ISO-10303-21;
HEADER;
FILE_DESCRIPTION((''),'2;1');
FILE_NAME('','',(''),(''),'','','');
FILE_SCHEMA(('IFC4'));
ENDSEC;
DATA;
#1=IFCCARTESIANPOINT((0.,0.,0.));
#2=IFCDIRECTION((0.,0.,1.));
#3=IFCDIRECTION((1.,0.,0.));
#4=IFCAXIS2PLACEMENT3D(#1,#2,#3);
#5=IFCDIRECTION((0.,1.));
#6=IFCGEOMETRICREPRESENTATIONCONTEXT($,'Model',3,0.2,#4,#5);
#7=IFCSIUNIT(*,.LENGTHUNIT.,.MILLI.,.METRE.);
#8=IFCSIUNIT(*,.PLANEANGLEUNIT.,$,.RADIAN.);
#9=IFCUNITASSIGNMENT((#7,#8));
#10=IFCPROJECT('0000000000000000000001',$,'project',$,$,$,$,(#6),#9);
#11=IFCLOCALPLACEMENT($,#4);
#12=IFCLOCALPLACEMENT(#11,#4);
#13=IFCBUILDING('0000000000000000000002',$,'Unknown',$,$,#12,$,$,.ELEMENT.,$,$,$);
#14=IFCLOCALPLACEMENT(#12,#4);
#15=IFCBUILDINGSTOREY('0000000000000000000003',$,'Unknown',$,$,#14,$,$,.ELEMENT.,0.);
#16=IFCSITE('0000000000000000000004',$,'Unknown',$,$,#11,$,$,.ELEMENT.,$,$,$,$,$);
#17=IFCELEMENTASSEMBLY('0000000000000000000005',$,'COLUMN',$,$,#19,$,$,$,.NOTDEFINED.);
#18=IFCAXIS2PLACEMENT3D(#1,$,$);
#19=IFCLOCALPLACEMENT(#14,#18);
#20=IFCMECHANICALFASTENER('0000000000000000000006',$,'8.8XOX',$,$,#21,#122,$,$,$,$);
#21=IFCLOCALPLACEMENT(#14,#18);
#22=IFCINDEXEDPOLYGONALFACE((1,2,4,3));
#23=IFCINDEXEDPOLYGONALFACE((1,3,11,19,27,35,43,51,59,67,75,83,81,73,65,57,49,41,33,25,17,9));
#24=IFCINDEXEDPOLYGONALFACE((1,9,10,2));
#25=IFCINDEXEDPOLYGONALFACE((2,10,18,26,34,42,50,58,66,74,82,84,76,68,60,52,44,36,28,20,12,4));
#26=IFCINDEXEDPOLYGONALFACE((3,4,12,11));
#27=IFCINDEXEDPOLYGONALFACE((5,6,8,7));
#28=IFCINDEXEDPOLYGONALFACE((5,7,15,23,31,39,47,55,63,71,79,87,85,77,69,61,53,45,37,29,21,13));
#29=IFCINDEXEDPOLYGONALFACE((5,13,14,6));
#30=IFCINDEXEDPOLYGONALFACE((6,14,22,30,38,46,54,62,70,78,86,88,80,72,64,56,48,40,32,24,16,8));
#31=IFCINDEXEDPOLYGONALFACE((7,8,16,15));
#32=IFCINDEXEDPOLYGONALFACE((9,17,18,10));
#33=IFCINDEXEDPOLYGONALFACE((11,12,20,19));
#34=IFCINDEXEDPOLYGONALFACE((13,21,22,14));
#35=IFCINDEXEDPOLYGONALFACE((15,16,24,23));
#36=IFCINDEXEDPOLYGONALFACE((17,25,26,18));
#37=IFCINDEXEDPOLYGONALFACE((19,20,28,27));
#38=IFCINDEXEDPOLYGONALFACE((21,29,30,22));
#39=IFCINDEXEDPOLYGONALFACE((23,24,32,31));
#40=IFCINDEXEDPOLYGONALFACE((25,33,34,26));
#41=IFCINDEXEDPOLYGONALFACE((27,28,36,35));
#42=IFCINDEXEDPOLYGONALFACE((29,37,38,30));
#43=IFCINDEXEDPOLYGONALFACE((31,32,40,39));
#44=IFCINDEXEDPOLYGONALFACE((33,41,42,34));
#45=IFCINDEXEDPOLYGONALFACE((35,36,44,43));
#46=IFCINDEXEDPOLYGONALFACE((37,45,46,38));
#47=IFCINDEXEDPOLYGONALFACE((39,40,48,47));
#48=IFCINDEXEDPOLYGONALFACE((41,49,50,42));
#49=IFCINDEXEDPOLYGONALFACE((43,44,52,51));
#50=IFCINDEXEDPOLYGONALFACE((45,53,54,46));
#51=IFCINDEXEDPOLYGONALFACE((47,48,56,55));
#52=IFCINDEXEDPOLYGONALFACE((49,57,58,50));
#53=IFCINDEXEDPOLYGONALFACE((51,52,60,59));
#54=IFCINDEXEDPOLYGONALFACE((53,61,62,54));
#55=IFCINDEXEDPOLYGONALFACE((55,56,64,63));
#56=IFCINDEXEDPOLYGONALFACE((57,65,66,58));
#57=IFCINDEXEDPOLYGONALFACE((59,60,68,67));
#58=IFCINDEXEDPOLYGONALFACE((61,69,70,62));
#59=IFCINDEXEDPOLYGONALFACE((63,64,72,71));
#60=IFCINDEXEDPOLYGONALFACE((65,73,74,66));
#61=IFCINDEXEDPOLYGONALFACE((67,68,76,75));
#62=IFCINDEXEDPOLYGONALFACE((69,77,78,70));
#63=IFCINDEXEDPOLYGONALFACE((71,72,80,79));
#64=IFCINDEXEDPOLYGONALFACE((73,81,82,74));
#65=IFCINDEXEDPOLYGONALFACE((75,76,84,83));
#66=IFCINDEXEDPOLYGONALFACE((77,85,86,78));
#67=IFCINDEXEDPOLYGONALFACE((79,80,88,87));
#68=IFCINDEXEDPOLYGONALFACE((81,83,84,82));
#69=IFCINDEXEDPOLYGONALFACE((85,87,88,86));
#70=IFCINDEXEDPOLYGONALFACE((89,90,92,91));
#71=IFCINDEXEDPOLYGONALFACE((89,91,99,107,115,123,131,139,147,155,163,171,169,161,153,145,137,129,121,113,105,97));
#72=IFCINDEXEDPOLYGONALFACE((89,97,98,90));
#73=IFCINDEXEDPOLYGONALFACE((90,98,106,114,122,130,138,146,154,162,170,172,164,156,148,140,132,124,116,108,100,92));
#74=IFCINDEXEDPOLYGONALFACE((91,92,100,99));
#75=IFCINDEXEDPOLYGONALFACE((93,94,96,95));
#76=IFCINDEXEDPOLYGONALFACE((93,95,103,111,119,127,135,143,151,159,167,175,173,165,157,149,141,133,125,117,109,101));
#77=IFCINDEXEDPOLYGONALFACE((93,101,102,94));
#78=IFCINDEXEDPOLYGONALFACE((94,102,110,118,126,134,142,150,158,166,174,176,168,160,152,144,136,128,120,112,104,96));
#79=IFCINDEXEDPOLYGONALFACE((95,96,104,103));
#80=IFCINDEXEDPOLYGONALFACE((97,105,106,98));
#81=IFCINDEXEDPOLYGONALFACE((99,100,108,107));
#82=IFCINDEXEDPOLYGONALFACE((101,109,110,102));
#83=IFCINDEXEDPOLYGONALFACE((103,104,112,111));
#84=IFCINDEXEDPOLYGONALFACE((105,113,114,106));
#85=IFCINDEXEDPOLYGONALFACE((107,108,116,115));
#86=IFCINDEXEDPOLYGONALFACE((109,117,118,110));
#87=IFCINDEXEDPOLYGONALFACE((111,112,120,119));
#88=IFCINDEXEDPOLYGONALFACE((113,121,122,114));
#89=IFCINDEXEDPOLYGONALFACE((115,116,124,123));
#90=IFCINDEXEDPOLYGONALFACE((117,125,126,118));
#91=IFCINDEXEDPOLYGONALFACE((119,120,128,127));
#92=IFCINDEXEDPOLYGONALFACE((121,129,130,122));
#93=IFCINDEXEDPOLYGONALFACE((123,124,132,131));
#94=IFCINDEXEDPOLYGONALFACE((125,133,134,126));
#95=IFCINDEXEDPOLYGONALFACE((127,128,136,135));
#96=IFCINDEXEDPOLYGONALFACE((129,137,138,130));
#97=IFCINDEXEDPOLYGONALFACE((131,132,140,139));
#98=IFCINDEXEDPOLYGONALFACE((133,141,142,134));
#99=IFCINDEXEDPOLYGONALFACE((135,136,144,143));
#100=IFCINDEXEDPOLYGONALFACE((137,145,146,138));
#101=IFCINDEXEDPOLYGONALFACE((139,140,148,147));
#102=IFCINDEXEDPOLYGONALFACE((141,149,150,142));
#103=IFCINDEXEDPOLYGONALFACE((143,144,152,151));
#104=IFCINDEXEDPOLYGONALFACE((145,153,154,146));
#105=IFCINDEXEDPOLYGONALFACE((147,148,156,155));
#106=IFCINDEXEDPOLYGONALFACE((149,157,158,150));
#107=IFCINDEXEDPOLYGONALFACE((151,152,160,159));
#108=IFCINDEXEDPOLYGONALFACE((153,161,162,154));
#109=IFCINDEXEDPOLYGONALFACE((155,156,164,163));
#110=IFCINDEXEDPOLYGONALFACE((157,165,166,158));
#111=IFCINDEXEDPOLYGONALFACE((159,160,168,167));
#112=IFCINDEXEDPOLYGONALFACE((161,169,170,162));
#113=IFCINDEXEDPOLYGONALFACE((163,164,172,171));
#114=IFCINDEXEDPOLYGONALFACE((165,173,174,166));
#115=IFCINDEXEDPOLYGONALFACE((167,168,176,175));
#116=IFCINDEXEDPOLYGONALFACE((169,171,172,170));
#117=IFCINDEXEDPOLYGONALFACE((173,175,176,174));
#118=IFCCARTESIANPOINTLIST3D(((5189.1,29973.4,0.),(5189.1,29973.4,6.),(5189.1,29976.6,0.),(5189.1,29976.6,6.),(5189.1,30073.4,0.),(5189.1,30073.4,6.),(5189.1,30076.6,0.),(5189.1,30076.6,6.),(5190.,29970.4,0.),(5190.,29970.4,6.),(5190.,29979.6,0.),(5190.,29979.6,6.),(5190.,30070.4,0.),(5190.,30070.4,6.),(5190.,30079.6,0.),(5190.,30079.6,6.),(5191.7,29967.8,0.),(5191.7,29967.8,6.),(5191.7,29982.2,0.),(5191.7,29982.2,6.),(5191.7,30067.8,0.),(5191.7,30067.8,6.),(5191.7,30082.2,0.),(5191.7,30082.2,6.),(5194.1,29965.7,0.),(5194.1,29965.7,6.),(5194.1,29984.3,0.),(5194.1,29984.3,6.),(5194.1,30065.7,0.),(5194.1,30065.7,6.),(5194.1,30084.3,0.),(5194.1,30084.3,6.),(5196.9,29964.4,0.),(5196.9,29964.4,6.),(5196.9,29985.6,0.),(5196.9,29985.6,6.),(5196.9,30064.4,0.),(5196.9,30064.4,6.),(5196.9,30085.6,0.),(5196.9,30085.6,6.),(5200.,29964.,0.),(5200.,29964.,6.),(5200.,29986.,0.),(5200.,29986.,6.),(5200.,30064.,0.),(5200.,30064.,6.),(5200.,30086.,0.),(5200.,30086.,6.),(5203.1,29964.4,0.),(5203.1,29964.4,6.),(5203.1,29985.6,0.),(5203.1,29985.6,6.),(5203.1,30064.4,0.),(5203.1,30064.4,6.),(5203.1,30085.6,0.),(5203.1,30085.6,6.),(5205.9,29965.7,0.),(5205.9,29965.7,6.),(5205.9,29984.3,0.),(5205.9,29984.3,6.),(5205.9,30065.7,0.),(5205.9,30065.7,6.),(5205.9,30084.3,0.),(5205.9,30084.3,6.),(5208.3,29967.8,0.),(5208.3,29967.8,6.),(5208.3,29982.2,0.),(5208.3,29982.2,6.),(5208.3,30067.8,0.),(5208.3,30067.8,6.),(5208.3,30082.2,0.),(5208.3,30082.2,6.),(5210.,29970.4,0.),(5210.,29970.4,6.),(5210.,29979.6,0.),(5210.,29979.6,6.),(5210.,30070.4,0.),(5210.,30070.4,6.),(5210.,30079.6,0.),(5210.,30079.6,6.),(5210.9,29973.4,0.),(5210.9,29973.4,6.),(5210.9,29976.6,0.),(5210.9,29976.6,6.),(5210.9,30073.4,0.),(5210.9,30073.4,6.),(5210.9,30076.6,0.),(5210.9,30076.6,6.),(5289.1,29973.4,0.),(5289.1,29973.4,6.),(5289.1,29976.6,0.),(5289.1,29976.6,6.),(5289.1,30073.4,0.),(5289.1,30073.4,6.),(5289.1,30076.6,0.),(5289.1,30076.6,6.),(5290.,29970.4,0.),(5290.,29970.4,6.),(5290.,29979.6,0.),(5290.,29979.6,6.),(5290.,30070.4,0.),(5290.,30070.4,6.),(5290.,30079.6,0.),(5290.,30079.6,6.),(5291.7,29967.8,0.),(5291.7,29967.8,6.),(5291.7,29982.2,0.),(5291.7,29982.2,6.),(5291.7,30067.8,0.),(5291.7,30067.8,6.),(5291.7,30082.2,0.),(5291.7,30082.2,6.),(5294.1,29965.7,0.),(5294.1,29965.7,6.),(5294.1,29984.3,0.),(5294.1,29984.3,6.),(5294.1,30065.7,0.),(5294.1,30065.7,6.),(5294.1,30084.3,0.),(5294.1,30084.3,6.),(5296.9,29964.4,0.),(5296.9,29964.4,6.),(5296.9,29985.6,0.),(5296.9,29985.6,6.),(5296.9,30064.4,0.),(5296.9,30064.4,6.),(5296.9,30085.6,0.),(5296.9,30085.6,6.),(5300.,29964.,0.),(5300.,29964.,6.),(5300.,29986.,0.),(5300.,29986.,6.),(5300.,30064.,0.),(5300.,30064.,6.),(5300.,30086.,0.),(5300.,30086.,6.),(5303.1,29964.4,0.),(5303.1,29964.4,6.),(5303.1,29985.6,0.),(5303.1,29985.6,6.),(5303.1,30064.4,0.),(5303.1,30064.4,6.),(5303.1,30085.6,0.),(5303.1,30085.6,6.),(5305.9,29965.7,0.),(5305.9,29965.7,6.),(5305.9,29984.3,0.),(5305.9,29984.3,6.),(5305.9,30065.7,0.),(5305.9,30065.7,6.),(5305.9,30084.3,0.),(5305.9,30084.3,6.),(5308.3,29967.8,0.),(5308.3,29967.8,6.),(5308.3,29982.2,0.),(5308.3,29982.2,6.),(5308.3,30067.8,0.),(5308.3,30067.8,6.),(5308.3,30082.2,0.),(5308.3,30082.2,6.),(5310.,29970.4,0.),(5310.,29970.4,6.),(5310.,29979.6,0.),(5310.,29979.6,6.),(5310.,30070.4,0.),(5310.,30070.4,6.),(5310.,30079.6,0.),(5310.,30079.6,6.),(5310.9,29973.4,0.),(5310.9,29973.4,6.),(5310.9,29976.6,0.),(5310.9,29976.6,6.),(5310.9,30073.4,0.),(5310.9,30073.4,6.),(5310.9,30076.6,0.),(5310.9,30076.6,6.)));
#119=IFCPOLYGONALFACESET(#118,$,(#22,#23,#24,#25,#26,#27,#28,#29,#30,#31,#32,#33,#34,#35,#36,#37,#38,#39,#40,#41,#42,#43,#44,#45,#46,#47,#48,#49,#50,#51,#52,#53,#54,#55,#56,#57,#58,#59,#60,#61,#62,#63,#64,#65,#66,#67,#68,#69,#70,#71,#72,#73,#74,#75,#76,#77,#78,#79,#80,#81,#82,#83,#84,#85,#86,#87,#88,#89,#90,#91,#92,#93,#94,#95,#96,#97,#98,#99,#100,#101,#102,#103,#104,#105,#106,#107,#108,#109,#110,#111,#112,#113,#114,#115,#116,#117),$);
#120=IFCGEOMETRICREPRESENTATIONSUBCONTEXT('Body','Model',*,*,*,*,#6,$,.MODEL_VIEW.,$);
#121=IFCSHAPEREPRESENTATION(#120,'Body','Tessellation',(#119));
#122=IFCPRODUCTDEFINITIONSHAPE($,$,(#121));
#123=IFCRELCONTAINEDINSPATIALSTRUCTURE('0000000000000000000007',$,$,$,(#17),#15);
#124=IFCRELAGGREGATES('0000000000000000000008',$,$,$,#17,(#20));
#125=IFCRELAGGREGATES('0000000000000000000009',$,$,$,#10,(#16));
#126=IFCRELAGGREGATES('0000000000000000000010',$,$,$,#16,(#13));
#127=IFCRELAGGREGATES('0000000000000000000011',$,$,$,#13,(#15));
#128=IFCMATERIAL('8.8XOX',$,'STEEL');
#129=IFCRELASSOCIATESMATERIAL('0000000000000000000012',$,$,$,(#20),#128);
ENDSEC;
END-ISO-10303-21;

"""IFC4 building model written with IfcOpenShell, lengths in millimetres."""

from ifc_helpers import new_model, si_unit, direction, frame, origin_with_axes, place, context, subcontext, project, spatial, arc, indexed_curve, outline, extrude, source, transform, mapped, material, element, aggregate, save


model = new_model("IFC4")

# Units and contexts
model_context = context("Model", 3, precision=0.2, world=origin_with_axes(), true_north=direction((0.0, 1.0)))
body_context = subcontext(model_context, "Body", "Model", "MODEL_VIEW")
ifc_project = project(units=[si_unit("LENGTHUNIT", "METRE", prefix="MILLI"), si_unit("PLANEANGLEUNIT", "RADIAN")], contexts=[model_context])

# Site, building, storey
site_placement = place(None, origin_with_axes())
site = spatial("IfcSite", under=ifc_project, at=site_placement, Name="Unknown", CompositionType="ELEMENT")
building_placement = place(site_placement, origin_with_axes())
building = spatial("IfcBuilding", under=site, at=building_placement, Name="Unknown", CompositionType="ELEMENT")
storey_placement = place(building_placement, origin_with_axes())
storey = spatial("IfcBuildingStorey", under=building, at=storey_placement, Name="Unknown", CompositionType="ELEMENT", Elevation=0.0)

# Element assembly
assembly_1_placement = place(storey_placement, frame((5250.0, 30025.0, 0.0), z_axis=(0.0, 1.0, 0.0), x_axis=(0.0, 0.0, 1.0)))
assembly_1 = element("IfcElementAssembly", 1, at=assembly_1_placement, inside=storey, Name="COLUMN", PredefinedType="NOTDEFINED")

# Shared definitions
ifc_material_1 = material(Name="8.8XOX", Category="STEEL")

# Mechanical fastener
shared_shape_1 = source(origin_with_axes(), body_context, "Body", "SweptSolid", [
    extrude(outline(indexed_curve([(11.0, 0.0), (0.0, 11.0), (-11.0, 0.0), (0.0, -11.0)], segments=[arc(1, 2, 3), arc(3, 4, 1)])), frame((0.0, 0.0, 0.0), z_axis=(0.0, 0.0, -1.0), x_axis=(0.0, 1.0, 0.0)), (0.0, 0.0, 1.0), 6.0),
])
mechanical_fastener_1_placement = place(assembly_1_placement, frame((6.0, 25.0, 0.0), z_axis=(1.0, 0.0, 0.0), x_axis=(0.0, -1.0, 0.0)))
mechanical_fastener_1 = element("IfcMechanicalFastener", 2, at=mechanical_fastener_1_placement, material=ifc_material_1, Name="8.8XOX", context=body_context, shape_type="MappedRepresentation", body=[
    mapped(shared_shape_1, transform((-25.0, 50.0, 0.0))),
    mapped(shared_shape_1, transform((-25.0, -50.0, 0.0))),
    mapped(shared_shape_1, transform((75.0, 50.0, 0.0))),
    mapped(shared_shape_1, transform((75.0, -50.0, 0.0))),
])
aggregate(assembly_1, [mechanical_fastener_1])

save(model, "model.ifc")
